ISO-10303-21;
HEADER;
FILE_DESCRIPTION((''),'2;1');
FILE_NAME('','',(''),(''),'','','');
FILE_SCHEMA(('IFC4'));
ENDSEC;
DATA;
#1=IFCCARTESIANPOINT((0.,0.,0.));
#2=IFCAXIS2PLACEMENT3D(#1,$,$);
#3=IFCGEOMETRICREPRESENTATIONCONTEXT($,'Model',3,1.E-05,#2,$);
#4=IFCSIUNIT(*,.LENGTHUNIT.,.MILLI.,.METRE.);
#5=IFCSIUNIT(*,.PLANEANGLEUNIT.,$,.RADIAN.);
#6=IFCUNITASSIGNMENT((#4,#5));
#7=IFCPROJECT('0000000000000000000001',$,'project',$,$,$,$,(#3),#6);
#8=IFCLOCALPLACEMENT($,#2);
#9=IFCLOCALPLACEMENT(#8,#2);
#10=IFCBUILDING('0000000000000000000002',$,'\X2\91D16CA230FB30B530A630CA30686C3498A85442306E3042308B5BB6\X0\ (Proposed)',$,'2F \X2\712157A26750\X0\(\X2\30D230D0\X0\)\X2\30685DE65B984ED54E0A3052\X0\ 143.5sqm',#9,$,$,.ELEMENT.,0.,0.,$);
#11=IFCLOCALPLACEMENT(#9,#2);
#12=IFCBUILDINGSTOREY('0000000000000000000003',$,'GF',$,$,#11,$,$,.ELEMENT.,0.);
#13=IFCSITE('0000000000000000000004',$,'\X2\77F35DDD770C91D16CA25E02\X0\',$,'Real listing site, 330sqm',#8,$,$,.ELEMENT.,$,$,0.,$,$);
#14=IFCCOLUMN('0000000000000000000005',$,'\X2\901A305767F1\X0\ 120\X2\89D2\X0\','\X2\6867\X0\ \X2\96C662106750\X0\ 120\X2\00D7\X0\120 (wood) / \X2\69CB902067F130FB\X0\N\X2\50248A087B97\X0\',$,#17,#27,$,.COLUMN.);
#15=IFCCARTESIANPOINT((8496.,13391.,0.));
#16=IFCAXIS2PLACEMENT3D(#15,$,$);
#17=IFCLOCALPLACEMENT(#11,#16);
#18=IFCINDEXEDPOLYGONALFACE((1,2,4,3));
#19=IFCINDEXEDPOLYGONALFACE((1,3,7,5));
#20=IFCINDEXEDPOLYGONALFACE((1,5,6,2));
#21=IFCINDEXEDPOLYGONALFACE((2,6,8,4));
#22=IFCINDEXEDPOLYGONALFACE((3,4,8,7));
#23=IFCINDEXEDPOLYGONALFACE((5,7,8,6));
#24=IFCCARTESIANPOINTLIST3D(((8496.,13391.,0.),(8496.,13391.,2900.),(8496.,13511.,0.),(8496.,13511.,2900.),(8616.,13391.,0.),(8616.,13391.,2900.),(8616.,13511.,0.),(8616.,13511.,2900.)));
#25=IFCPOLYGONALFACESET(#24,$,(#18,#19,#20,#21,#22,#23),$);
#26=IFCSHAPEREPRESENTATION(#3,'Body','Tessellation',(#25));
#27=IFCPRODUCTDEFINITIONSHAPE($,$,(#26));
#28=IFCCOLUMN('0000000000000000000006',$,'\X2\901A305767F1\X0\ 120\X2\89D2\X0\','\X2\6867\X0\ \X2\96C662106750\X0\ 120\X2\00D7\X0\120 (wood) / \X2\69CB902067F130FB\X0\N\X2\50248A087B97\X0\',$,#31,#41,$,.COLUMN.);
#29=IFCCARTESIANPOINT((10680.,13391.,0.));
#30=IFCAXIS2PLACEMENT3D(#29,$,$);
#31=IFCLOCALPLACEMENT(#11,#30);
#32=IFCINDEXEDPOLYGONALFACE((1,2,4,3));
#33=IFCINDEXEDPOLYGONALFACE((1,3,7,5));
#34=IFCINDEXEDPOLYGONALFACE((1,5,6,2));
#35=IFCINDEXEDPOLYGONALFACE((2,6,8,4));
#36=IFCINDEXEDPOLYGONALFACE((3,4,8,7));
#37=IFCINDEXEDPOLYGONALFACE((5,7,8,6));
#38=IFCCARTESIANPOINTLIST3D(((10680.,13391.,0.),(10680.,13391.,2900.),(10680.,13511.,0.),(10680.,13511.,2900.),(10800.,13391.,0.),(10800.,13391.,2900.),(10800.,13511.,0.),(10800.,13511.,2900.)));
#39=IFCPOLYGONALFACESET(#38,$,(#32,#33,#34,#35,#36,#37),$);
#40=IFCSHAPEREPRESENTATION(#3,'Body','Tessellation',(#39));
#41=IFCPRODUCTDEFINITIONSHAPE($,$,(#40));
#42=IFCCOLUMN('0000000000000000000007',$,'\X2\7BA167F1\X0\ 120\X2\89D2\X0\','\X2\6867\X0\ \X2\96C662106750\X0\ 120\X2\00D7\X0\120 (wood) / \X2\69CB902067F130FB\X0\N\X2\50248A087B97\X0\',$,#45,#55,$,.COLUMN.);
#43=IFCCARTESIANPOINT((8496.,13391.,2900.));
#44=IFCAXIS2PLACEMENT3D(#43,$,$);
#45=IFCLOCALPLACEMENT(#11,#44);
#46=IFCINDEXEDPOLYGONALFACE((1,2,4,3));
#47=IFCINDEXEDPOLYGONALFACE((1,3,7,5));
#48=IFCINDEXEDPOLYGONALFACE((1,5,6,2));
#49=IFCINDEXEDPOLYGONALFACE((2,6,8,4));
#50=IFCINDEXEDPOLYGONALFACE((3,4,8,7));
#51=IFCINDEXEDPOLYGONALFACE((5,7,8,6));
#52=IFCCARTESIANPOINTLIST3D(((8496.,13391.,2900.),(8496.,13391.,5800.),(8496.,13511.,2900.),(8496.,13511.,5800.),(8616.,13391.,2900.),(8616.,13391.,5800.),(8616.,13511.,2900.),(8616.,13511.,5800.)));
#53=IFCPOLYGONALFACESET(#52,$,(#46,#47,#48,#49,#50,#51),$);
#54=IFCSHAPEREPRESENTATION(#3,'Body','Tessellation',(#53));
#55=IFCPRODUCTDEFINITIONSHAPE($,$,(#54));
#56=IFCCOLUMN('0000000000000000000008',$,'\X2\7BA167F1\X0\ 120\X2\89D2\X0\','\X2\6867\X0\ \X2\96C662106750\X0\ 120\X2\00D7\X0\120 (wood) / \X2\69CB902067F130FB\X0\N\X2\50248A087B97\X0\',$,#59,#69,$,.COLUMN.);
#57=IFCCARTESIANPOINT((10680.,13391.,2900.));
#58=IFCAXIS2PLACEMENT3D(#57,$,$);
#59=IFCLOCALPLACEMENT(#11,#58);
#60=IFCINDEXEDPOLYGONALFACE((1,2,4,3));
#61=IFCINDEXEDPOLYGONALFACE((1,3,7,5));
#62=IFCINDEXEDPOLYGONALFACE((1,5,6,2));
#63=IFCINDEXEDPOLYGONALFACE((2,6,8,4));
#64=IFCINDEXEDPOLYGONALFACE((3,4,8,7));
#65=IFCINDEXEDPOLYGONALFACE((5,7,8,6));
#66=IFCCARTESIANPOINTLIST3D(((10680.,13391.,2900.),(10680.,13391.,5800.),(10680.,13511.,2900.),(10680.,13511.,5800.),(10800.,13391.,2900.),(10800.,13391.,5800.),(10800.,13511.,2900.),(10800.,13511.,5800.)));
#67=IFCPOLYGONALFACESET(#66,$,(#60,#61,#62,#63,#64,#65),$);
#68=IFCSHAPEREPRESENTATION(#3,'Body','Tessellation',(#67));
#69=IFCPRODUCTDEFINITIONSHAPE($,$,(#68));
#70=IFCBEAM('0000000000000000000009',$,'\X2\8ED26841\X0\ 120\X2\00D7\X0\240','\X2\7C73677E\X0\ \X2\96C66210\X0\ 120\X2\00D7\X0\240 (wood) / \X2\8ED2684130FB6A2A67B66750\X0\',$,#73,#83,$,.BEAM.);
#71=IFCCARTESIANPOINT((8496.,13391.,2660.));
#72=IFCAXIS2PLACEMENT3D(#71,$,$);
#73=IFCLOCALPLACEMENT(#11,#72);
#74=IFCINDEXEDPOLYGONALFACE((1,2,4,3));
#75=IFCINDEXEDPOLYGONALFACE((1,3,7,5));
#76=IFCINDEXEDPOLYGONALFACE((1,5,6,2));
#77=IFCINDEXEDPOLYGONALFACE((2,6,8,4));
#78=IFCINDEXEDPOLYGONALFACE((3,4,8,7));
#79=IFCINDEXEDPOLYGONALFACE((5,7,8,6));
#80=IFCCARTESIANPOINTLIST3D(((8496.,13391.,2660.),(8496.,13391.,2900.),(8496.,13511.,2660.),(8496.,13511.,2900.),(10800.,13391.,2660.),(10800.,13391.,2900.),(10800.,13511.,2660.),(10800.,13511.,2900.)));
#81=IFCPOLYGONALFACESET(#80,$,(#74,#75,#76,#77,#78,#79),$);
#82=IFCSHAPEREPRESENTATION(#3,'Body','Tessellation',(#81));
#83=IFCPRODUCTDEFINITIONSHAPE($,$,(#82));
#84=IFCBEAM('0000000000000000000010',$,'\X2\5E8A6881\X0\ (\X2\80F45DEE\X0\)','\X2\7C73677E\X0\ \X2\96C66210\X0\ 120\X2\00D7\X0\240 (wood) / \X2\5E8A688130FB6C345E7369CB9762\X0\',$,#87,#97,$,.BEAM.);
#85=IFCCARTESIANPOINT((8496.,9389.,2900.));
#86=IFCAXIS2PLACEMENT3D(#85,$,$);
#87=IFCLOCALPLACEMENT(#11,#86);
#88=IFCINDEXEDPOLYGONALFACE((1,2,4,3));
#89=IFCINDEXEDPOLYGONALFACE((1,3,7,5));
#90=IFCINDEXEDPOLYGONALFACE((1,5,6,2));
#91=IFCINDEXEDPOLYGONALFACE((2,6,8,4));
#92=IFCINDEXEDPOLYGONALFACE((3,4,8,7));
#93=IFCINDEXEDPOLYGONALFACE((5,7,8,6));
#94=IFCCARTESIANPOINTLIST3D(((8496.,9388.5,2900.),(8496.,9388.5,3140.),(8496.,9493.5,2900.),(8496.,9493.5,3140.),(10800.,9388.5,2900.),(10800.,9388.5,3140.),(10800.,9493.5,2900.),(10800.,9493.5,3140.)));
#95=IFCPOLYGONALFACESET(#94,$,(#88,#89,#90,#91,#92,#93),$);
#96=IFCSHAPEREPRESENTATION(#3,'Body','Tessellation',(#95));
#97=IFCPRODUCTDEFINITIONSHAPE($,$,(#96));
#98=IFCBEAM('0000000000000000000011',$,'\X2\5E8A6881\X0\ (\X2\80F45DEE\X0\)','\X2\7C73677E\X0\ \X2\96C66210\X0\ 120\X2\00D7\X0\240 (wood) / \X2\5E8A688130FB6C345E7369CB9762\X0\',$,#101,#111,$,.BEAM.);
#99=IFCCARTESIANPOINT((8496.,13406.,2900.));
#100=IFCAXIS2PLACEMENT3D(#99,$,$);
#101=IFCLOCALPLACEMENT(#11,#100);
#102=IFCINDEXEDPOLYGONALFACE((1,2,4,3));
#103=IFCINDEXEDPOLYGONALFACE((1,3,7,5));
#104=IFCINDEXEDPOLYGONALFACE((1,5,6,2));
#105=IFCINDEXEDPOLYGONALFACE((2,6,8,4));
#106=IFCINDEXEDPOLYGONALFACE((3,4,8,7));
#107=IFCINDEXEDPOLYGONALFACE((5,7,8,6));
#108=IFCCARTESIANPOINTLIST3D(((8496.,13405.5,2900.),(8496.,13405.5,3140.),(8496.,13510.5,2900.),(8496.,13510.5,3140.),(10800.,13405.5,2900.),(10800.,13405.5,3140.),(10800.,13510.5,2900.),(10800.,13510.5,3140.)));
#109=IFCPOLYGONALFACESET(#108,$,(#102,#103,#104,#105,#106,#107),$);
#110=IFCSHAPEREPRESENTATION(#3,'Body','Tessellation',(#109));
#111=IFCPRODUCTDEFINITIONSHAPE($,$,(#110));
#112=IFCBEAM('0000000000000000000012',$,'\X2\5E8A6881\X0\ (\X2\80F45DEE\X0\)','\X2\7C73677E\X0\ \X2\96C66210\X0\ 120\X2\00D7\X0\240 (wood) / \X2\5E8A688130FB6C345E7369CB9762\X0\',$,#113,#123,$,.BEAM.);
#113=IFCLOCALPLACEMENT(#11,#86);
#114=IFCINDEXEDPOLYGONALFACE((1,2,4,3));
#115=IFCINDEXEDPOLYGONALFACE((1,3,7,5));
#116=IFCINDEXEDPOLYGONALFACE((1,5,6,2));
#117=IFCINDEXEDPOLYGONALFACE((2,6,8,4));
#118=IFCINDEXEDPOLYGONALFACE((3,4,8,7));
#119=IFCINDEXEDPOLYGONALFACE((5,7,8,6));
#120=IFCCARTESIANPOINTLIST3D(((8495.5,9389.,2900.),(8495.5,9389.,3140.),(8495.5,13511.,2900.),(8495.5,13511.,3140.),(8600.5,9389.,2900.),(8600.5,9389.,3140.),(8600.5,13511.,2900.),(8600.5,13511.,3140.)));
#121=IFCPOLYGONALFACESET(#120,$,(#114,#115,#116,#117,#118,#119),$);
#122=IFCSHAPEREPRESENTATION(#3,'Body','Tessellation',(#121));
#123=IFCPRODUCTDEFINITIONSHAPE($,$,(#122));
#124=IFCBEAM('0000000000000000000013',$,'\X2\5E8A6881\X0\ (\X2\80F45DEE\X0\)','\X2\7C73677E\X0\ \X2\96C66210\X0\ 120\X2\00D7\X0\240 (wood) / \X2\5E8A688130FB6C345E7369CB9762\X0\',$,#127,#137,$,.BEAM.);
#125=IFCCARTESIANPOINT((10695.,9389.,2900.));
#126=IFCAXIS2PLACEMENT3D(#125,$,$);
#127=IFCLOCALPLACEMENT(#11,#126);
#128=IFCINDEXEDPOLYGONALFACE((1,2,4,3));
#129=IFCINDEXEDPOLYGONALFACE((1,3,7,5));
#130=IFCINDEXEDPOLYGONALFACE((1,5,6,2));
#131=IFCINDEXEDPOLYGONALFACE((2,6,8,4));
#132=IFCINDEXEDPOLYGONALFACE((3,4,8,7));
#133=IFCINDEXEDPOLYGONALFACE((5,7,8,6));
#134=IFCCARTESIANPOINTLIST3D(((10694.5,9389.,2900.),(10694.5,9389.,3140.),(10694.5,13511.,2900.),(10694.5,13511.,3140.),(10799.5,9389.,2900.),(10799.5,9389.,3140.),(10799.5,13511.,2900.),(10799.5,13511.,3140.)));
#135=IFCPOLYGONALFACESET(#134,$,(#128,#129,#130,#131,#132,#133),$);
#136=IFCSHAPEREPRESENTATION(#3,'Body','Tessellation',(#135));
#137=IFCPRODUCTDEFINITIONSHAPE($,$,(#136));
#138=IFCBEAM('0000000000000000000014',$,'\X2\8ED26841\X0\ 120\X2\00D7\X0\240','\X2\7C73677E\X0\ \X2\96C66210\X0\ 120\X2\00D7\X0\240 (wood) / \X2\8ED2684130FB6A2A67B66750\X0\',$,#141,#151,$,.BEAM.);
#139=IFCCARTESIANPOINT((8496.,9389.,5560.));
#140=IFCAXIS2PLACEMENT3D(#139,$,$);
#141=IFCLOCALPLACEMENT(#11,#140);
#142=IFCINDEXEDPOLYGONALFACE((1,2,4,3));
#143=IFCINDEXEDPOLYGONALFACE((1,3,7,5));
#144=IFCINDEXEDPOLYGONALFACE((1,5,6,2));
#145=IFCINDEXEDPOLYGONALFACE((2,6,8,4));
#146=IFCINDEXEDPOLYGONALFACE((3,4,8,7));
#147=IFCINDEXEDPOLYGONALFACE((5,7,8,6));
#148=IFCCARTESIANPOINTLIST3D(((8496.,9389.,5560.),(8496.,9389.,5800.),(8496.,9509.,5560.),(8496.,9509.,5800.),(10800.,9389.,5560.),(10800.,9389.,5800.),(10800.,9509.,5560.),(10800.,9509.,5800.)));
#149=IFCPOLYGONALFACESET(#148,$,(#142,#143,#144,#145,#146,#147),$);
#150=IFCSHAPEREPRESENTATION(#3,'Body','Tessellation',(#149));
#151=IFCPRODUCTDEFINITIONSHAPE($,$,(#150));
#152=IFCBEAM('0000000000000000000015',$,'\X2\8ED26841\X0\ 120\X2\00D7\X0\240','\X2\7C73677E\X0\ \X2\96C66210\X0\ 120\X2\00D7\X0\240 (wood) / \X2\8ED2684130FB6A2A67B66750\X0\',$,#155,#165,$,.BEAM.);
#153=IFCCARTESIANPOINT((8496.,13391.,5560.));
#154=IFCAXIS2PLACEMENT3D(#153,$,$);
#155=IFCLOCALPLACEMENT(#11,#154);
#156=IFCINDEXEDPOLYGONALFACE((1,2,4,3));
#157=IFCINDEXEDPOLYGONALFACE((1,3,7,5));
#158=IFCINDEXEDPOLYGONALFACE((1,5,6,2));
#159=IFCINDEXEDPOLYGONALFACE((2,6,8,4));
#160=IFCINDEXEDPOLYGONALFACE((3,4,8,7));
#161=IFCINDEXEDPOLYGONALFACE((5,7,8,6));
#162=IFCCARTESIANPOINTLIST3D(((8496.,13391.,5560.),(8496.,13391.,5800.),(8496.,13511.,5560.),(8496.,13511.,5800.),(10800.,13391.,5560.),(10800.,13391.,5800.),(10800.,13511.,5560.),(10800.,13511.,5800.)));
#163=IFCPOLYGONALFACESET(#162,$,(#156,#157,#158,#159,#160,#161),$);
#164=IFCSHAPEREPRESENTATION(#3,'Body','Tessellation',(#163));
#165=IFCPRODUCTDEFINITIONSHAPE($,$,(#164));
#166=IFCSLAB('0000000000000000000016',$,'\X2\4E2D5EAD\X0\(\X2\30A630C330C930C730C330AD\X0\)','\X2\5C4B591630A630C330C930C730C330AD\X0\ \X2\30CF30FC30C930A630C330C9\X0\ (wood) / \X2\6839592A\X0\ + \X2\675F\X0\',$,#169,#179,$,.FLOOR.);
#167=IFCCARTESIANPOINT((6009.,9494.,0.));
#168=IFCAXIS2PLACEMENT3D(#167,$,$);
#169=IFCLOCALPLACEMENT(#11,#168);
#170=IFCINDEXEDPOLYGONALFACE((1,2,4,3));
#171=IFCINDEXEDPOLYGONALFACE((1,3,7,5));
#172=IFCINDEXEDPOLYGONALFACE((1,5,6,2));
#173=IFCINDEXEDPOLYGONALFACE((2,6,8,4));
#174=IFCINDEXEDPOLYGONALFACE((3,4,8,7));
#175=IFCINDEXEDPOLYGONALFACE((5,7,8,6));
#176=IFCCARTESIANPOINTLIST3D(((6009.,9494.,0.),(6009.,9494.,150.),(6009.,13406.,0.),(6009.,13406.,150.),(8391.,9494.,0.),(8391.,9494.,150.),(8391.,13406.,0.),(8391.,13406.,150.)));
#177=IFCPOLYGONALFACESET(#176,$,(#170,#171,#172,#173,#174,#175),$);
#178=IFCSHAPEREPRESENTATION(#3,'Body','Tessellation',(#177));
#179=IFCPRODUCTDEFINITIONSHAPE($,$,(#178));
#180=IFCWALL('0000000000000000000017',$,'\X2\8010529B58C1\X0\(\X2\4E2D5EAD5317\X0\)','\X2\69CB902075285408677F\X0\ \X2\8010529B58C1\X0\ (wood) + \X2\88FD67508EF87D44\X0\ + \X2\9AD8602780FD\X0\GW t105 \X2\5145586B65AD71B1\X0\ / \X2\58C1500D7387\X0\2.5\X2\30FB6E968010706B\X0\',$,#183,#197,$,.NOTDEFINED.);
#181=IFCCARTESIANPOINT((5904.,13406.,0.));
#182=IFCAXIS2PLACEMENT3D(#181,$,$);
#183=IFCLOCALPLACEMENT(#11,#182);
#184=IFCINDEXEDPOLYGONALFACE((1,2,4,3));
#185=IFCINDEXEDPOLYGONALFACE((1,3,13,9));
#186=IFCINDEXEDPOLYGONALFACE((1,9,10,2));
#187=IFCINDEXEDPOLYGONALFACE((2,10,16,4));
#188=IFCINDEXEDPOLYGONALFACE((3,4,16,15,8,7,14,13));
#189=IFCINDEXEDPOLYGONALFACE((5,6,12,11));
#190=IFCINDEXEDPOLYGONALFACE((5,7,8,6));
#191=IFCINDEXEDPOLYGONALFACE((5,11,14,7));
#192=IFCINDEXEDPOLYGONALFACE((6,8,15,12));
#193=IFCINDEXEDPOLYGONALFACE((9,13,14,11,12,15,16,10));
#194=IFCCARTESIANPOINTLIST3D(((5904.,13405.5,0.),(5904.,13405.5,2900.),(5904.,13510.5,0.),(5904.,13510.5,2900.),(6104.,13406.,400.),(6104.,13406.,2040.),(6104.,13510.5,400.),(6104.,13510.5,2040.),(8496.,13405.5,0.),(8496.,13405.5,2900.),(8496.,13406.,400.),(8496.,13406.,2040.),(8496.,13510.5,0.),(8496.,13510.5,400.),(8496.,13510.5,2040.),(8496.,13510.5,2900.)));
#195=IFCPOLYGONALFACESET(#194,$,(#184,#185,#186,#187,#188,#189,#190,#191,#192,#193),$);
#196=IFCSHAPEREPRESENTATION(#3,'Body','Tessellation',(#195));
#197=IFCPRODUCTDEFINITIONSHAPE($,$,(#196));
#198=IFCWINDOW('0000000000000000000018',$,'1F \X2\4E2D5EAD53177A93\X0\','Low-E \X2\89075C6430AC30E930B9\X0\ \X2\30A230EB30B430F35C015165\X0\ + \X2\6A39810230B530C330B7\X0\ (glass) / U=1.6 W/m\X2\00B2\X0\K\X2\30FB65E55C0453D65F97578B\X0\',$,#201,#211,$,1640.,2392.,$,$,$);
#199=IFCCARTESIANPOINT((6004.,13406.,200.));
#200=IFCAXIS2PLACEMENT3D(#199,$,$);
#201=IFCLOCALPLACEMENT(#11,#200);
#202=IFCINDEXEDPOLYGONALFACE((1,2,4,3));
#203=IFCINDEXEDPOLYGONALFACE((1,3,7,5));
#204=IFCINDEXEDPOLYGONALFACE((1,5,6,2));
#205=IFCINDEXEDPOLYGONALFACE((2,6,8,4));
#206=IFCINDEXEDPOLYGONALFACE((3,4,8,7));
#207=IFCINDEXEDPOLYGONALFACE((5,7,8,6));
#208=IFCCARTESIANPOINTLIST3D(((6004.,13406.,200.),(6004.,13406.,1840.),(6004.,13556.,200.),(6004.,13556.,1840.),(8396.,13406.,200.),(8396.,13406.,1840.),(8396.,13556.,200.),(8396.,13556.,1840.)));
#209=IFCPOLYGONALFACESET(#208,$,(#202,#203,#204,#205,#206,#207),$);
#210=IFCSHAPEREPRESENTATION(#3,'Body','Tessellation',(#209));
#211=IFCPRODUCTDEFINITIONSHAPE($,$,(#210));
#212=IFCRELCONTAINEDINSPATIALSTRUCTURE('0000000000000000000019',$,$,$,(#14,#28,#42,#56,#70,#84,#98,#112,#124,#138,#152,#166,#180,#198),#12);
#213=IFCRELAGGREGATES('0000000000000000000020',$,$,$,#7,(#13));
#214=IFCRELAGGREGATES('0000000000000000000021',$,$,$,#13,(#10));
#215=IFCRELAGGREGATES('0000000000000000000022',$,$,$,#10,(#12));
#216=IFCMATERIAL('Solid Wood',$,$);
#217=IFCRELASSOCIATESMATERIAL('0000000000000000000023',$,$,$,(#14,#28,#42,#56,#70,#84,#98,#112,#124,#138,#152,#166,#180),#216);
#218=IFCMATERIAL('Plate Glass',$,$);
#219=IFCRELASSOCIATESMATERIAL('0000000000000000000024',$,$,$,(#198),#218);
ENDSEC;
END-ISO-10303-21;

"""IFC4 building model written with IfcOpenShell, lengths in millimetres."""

from ifc_helpers import new_model, si_unit, frame, frame_2d, origin, place, context, project, spatial, rectangle, extrude, material, element, fill, save


model = new_model("IFC4")

# Units and contexts
model_context = context("Model", 3, precision=1e-05, world=origin())
ifc_project = project(units=[si_unit("LENGTHUNIT", "METRE", prefix="MILLI"), si_unit("PLANEANGLEUNIT", "RADIAN")], contexts=[model_context])

# Site, building, storey
site_placement = place(None, origin())
site = spatial("IfcSite", under=ifc_project, at=site_placement, Name="石川県金沢市", ObjectType="Real listing site, 330sqm", CompositionType="ELEMENT", RefElevation=0.0)
building_placement = place(site_placement, origin())
building = spatial("IfcBuilding", under=site, at=building_placement, Name="金沢・サウナと水風呂のある家 (Proposed)", ObjectType="2F 無垢材(ヒバ)と左官仕上げ 143.5sqm", CompositionType="ELEMENT", ElevationOfRefHeight=0.0, ElevationOfTerrain=0.0)
storey_placement = place(building_placement, origin())
storey = spatial("IfcBuildingStorey", under=building, at=storey_placement, Name="GF", CompositionType="ELEMENT", Elevation=0.0)

# Columns
ifc_material_1 = material(Name="Solid Wood")
column_1_placement = place(storey_placement, frame((8496.0, 13391.0, 0.0)))
element("IfcColumn", 1, at=column_1_placement, inside=storey, material=ifc_material_1, Name="通し柱 120角", Description="桧 集成材 120×120 (wood) / 構造柱・N値計算", PredefinedType="COLUMN", context=model_context, shape_type="SweptSolid", body=[
    extrude(rectangle(XDim=120.0, YDim=120.0, at=frame_2d((60.0, 60.0))), frame((8496.0, 13391.0, 0.0)), (0.0, 0.0, 1.0), 2900.0),
])
column_2_placement = place(storey_placement, frame((10680.0, 13391.0, 0.0)))
element("IfcColumn", 2, at=column_2_placement, inside=storey, material=ifc_material_1, Name="通し柱 120角", Description="桧 集成材 120×120 (wood) / 構造柱・N値計算", PredefinedType="COLUMN", context=model_context, shape_type="SweptSolid", body=[
    extrude(rectangle(XDim=120.0, YDim=120.0, at=frame_2d((60.0, 60.0))), frame((10680.0, 13391.0, 0.0)), (0.0, 0.0, 1.0), 2900.0),
])
column_3_placement = place(storey_placement, frame((8496.0, 13391.0, 2900.0)))
element("IfcColumn", 3, at=column_3_placement, inside=storey, material=ifc_material_1, Name="管柱 120角", Description="桧 集成材 120×120 (wood) / 構造柱・N値計算", PredefinedType="COLUMN", context=model_context, shape_type="SweptSolid", body=[
    extrude(rectangle(XDim=120.0, YDim=120.0, at=frame_2d((60.0, 60.0))), frame((8496.0, 13391.0, 2900.0)), (0.0, 0.0, 1.0), 2900.0),
])
column_4_placement = place(storey_placement, frame((10680.0, 13391.0, 2900.0)))
element("IfcColumn", 4, at=column_4_placement, inside=storey, material=ifc_material_1, Name="管柱 120角", Description="桧 集成材 120×120 (wood) / 構造柱・N値計算", PredefinedType="COLUMN", context=model_context, shape_type="SweptSolid", body=[
    extrude(rectangle(XDim=120.0, YDim=120.0, at=frame_2d((60.0, 60.0))), frame((10680.0, 13391.0, 2900.0)), (0.0, 0.0, 1.0), 2900.0),
])

# Beams
beam_1_placement = place(storey_placement, frame((8496.0, 13391.0, 2660.0)))
element("IfcBeam", 5, at=beam_1_placement, inside=storey, material=ifc_material_1, Name="軒桁 120×240", Description="米松 集成 120×240 (wood) / 軒桁・横架材", PredefinedType="BEAM", context=model_context, shape_type="SweptSolid", body=[
    extrude(rectangle(XDim=2304.0, YDim=120.0, at=frame_2d((1152.0, 60.0))), frame((8496.0, 13391.0, 2660.0)), (0.0, 0.0, 1.0), 240.0),
])
beam_2_placement = place(storey_placement, frame((8496.0, 9389.0, 2900.0)))
element("IfcBeam", 6, at=beam_2_placement, inside=storey, material=ifc_material_1, Name="床梁 (胴差)", Description="米松 集成 120×240 (wood) / 床梁・水平構面", PredefinedType="BEAM", context=model_context, shape_type="SweptSolid", body=[
    extrude(rectangle(XDim=2304.0, YDim=105.0, at=frame_2d((1152.0, 52.0))), frame((8496.0, 9389.0, 2900.0)), (0.0, 0.0, 1.0), 240.0),
])
beam_3_placement = place(storey_placement, frame((8496.0, 13406.0, 2900.0)))
element("IfcBeam", 7, at=beam_3_placement, inside=storey, material=ifc_material_1, Name="床梁 (胴差)", Description="米松 集成 120×240 (wood) / 床梁・水平構面", PredefinedType="BEAM", context=model_context, shape_type="SweptSolid", body=[
    extrude(rectangle(XDim=2304.0, YDim=105.0, at=frame_2d((1152.0, 52.0))), frame((8496.0, 13406.0, 2900.0)), (0.0, 0.0, 1.0), 240.0),
])
beam_4_placement = place(storey_placement, frame((8496.0, 9389.0, 2900.0)))
element("IfcBeam", 8, at=beam_4_placement, inside=storey, material=ifc_material_1, Name="床梁 (胴差)", Description="米松 集成 120×240 (wood) / 床梁・水平構面", PredefinedType="BEAM", context=model_context, shape_type="SweptSolid", body=[
    extrude(rectangle(XDim=105.0, YDim=4122.0, at=frame_2d((52.0, 2061.0))), frame((8496.0, 9389.0, 2900.0)), (0.0, 0.0, 1.0), 240.0),
])
beam_5_placement = place(storey_placement, frame((10695.0, 9389.0, 2900.0)))
element("IfcBeam", 9, at=beam_5_placement, inside=storey, material=ifc_material_1, Name="床梁 (胴差)", Description="米松 集成 120×240 (wood) / 床梁・水平構面", PredefinedType="BEAM", context=model_context, shape_type="SweptSolid", body=[
    extrude(rectangle(XDim=105.0, YDim=4122.0, at=frame_2d((52.0, 2061.0))), frame((10695.0, 9389.0, 2900.0)), (0.0, 0.0, 1.0), 240.0),
])
beam_6_placement = place(storey_placement, frame((8496.0, 9389.0, 5560.0)))
element("IfcBeam", 10, at=beam_6_placement, inside=storey, material=ifc_material_1, Name="軒桁 120×240", Description="米松 集成 120×240 (wood) / 軒桁・横架材", PredefinedType="BEAM", context=model_context, shape_type="SweptSolid", body=[
    extrude(rectangle(XDim=2304.0, YDim=120.0, at=frame_2d((1152.0, 60.0))), frame((8496.0, 9389.0, 5560.0)), (0.0, 0.0, 1.0), 240.0),
])
beam_7_placement = place(storey_placement, frame((8496.0, 13391.0, 5560.0)))
element("IfcBeam", 11, at=beam_7_placement, inside=storey, material=ifc_material_1, Name="軒桁 120×240", Description="米松 集成 120×240 (wood) / 軒桁・横架材", PredefinedType="BEAM", context=model_context, shape_type="SweptSolid", body=[
    extrude(rectangle(XDim=2304.0, YDim=120.0, at=frame_2d((1152.0, 60.0))), frame((8496.0, 13391.0, 5560.0)), (0.0, 0.0, 1.0), 240.0),
])

# Slab
slab_placement = place(storey_placement, frame((6009.0, 9494.0, 0.0)))
element("IfcSlab", 12, at=slab_placement, inside=storey, material=ifc_material_1, Name="中庭(ウッドデッキ)", Description="屋外ウッドデッキ ハードウッド (wood) / 根太 + 束", PredefinedType="FLOOR", context=model_context, shape_type="SweptSolid", body=[
    extrude(rectangle(XDim=2382.0, YDim=3912.0, at=frame_2d((1191.0, 1956.0))), frame((6009.0, 9494.0, 0.0)), (0.0, 0.0, 1.0), 150.0),
])

# Wall, opening, window
wall_1_placement = place(storey_placement, frame((5904.0, 13406.0, 0.0)))
wall_1 = element("IfcWall", 13, at=wall_1_placement, inside=storey, material=ifc_material_1, Name="耐力壁(中庭北)", Description="構造用合板 耐力壁 (wood) + 製材軸組 + 高性能GW t105 充填断熱 / 壁倍率2.5・準耐火", PredefinedType="NOTDEFINED", context=model_context, shape_type="SweptSolid", body=[
    extrude(rectangle(XDim=2592.0, YDim=105.0, at=frame_2d((1296.0, 52.0))), frame((5904.0, 13406.0, 0.0)), (0.0, 0.0, 1.0), 2900.0),
])
opening_1_placement = place(storey_placement, frame((6004.0, 13406.0, 200.0)))
opening_1 = element("IfcOpeningElement", 14, at=opening_1_placement, cuts=wall_1, PredefinedType="NOTDEFINED", context=model_context, shape_type="SweptSolid", body=[
    extrude(rectangle(XDim=2392.0, YDim=150.0, at=frame_2d((1196.0, 75.0))), frame((6004.0, 13406.0, 200.0)), (0.0, 0.0, 1.0), 1640.0),
])
ifc_material_2 = material(Name="Plate Glass")
window_1_placement = place(storey_placement, frame((6004.0, 13406.0, 200.0)))
window_1 = element("IfcWindow", 15, at=window_1_placement, inside=storey, material=ifc_material_2, Name="1F 中庭北窓", Description="Low-E 複層ガラス アルゴン封入 + 樹脂サッシ (glass) / U=1.6 W/m²K・日射取得型", OverallHeight=1640.0, OverallWidth=2392.0, context=model_context, shape_type="SweptSolid", body=[
    extrude(rectangle(XDim=2392.0, YDim=150.0, at=frame_2d((1196.0, 75.0))), frame((6004.0, 13406.0, 200.0)), (0.0, 0.0, 1.0), 1640.0),
])
fill(opening_1, window_1)

save(model, "model.ifc")
